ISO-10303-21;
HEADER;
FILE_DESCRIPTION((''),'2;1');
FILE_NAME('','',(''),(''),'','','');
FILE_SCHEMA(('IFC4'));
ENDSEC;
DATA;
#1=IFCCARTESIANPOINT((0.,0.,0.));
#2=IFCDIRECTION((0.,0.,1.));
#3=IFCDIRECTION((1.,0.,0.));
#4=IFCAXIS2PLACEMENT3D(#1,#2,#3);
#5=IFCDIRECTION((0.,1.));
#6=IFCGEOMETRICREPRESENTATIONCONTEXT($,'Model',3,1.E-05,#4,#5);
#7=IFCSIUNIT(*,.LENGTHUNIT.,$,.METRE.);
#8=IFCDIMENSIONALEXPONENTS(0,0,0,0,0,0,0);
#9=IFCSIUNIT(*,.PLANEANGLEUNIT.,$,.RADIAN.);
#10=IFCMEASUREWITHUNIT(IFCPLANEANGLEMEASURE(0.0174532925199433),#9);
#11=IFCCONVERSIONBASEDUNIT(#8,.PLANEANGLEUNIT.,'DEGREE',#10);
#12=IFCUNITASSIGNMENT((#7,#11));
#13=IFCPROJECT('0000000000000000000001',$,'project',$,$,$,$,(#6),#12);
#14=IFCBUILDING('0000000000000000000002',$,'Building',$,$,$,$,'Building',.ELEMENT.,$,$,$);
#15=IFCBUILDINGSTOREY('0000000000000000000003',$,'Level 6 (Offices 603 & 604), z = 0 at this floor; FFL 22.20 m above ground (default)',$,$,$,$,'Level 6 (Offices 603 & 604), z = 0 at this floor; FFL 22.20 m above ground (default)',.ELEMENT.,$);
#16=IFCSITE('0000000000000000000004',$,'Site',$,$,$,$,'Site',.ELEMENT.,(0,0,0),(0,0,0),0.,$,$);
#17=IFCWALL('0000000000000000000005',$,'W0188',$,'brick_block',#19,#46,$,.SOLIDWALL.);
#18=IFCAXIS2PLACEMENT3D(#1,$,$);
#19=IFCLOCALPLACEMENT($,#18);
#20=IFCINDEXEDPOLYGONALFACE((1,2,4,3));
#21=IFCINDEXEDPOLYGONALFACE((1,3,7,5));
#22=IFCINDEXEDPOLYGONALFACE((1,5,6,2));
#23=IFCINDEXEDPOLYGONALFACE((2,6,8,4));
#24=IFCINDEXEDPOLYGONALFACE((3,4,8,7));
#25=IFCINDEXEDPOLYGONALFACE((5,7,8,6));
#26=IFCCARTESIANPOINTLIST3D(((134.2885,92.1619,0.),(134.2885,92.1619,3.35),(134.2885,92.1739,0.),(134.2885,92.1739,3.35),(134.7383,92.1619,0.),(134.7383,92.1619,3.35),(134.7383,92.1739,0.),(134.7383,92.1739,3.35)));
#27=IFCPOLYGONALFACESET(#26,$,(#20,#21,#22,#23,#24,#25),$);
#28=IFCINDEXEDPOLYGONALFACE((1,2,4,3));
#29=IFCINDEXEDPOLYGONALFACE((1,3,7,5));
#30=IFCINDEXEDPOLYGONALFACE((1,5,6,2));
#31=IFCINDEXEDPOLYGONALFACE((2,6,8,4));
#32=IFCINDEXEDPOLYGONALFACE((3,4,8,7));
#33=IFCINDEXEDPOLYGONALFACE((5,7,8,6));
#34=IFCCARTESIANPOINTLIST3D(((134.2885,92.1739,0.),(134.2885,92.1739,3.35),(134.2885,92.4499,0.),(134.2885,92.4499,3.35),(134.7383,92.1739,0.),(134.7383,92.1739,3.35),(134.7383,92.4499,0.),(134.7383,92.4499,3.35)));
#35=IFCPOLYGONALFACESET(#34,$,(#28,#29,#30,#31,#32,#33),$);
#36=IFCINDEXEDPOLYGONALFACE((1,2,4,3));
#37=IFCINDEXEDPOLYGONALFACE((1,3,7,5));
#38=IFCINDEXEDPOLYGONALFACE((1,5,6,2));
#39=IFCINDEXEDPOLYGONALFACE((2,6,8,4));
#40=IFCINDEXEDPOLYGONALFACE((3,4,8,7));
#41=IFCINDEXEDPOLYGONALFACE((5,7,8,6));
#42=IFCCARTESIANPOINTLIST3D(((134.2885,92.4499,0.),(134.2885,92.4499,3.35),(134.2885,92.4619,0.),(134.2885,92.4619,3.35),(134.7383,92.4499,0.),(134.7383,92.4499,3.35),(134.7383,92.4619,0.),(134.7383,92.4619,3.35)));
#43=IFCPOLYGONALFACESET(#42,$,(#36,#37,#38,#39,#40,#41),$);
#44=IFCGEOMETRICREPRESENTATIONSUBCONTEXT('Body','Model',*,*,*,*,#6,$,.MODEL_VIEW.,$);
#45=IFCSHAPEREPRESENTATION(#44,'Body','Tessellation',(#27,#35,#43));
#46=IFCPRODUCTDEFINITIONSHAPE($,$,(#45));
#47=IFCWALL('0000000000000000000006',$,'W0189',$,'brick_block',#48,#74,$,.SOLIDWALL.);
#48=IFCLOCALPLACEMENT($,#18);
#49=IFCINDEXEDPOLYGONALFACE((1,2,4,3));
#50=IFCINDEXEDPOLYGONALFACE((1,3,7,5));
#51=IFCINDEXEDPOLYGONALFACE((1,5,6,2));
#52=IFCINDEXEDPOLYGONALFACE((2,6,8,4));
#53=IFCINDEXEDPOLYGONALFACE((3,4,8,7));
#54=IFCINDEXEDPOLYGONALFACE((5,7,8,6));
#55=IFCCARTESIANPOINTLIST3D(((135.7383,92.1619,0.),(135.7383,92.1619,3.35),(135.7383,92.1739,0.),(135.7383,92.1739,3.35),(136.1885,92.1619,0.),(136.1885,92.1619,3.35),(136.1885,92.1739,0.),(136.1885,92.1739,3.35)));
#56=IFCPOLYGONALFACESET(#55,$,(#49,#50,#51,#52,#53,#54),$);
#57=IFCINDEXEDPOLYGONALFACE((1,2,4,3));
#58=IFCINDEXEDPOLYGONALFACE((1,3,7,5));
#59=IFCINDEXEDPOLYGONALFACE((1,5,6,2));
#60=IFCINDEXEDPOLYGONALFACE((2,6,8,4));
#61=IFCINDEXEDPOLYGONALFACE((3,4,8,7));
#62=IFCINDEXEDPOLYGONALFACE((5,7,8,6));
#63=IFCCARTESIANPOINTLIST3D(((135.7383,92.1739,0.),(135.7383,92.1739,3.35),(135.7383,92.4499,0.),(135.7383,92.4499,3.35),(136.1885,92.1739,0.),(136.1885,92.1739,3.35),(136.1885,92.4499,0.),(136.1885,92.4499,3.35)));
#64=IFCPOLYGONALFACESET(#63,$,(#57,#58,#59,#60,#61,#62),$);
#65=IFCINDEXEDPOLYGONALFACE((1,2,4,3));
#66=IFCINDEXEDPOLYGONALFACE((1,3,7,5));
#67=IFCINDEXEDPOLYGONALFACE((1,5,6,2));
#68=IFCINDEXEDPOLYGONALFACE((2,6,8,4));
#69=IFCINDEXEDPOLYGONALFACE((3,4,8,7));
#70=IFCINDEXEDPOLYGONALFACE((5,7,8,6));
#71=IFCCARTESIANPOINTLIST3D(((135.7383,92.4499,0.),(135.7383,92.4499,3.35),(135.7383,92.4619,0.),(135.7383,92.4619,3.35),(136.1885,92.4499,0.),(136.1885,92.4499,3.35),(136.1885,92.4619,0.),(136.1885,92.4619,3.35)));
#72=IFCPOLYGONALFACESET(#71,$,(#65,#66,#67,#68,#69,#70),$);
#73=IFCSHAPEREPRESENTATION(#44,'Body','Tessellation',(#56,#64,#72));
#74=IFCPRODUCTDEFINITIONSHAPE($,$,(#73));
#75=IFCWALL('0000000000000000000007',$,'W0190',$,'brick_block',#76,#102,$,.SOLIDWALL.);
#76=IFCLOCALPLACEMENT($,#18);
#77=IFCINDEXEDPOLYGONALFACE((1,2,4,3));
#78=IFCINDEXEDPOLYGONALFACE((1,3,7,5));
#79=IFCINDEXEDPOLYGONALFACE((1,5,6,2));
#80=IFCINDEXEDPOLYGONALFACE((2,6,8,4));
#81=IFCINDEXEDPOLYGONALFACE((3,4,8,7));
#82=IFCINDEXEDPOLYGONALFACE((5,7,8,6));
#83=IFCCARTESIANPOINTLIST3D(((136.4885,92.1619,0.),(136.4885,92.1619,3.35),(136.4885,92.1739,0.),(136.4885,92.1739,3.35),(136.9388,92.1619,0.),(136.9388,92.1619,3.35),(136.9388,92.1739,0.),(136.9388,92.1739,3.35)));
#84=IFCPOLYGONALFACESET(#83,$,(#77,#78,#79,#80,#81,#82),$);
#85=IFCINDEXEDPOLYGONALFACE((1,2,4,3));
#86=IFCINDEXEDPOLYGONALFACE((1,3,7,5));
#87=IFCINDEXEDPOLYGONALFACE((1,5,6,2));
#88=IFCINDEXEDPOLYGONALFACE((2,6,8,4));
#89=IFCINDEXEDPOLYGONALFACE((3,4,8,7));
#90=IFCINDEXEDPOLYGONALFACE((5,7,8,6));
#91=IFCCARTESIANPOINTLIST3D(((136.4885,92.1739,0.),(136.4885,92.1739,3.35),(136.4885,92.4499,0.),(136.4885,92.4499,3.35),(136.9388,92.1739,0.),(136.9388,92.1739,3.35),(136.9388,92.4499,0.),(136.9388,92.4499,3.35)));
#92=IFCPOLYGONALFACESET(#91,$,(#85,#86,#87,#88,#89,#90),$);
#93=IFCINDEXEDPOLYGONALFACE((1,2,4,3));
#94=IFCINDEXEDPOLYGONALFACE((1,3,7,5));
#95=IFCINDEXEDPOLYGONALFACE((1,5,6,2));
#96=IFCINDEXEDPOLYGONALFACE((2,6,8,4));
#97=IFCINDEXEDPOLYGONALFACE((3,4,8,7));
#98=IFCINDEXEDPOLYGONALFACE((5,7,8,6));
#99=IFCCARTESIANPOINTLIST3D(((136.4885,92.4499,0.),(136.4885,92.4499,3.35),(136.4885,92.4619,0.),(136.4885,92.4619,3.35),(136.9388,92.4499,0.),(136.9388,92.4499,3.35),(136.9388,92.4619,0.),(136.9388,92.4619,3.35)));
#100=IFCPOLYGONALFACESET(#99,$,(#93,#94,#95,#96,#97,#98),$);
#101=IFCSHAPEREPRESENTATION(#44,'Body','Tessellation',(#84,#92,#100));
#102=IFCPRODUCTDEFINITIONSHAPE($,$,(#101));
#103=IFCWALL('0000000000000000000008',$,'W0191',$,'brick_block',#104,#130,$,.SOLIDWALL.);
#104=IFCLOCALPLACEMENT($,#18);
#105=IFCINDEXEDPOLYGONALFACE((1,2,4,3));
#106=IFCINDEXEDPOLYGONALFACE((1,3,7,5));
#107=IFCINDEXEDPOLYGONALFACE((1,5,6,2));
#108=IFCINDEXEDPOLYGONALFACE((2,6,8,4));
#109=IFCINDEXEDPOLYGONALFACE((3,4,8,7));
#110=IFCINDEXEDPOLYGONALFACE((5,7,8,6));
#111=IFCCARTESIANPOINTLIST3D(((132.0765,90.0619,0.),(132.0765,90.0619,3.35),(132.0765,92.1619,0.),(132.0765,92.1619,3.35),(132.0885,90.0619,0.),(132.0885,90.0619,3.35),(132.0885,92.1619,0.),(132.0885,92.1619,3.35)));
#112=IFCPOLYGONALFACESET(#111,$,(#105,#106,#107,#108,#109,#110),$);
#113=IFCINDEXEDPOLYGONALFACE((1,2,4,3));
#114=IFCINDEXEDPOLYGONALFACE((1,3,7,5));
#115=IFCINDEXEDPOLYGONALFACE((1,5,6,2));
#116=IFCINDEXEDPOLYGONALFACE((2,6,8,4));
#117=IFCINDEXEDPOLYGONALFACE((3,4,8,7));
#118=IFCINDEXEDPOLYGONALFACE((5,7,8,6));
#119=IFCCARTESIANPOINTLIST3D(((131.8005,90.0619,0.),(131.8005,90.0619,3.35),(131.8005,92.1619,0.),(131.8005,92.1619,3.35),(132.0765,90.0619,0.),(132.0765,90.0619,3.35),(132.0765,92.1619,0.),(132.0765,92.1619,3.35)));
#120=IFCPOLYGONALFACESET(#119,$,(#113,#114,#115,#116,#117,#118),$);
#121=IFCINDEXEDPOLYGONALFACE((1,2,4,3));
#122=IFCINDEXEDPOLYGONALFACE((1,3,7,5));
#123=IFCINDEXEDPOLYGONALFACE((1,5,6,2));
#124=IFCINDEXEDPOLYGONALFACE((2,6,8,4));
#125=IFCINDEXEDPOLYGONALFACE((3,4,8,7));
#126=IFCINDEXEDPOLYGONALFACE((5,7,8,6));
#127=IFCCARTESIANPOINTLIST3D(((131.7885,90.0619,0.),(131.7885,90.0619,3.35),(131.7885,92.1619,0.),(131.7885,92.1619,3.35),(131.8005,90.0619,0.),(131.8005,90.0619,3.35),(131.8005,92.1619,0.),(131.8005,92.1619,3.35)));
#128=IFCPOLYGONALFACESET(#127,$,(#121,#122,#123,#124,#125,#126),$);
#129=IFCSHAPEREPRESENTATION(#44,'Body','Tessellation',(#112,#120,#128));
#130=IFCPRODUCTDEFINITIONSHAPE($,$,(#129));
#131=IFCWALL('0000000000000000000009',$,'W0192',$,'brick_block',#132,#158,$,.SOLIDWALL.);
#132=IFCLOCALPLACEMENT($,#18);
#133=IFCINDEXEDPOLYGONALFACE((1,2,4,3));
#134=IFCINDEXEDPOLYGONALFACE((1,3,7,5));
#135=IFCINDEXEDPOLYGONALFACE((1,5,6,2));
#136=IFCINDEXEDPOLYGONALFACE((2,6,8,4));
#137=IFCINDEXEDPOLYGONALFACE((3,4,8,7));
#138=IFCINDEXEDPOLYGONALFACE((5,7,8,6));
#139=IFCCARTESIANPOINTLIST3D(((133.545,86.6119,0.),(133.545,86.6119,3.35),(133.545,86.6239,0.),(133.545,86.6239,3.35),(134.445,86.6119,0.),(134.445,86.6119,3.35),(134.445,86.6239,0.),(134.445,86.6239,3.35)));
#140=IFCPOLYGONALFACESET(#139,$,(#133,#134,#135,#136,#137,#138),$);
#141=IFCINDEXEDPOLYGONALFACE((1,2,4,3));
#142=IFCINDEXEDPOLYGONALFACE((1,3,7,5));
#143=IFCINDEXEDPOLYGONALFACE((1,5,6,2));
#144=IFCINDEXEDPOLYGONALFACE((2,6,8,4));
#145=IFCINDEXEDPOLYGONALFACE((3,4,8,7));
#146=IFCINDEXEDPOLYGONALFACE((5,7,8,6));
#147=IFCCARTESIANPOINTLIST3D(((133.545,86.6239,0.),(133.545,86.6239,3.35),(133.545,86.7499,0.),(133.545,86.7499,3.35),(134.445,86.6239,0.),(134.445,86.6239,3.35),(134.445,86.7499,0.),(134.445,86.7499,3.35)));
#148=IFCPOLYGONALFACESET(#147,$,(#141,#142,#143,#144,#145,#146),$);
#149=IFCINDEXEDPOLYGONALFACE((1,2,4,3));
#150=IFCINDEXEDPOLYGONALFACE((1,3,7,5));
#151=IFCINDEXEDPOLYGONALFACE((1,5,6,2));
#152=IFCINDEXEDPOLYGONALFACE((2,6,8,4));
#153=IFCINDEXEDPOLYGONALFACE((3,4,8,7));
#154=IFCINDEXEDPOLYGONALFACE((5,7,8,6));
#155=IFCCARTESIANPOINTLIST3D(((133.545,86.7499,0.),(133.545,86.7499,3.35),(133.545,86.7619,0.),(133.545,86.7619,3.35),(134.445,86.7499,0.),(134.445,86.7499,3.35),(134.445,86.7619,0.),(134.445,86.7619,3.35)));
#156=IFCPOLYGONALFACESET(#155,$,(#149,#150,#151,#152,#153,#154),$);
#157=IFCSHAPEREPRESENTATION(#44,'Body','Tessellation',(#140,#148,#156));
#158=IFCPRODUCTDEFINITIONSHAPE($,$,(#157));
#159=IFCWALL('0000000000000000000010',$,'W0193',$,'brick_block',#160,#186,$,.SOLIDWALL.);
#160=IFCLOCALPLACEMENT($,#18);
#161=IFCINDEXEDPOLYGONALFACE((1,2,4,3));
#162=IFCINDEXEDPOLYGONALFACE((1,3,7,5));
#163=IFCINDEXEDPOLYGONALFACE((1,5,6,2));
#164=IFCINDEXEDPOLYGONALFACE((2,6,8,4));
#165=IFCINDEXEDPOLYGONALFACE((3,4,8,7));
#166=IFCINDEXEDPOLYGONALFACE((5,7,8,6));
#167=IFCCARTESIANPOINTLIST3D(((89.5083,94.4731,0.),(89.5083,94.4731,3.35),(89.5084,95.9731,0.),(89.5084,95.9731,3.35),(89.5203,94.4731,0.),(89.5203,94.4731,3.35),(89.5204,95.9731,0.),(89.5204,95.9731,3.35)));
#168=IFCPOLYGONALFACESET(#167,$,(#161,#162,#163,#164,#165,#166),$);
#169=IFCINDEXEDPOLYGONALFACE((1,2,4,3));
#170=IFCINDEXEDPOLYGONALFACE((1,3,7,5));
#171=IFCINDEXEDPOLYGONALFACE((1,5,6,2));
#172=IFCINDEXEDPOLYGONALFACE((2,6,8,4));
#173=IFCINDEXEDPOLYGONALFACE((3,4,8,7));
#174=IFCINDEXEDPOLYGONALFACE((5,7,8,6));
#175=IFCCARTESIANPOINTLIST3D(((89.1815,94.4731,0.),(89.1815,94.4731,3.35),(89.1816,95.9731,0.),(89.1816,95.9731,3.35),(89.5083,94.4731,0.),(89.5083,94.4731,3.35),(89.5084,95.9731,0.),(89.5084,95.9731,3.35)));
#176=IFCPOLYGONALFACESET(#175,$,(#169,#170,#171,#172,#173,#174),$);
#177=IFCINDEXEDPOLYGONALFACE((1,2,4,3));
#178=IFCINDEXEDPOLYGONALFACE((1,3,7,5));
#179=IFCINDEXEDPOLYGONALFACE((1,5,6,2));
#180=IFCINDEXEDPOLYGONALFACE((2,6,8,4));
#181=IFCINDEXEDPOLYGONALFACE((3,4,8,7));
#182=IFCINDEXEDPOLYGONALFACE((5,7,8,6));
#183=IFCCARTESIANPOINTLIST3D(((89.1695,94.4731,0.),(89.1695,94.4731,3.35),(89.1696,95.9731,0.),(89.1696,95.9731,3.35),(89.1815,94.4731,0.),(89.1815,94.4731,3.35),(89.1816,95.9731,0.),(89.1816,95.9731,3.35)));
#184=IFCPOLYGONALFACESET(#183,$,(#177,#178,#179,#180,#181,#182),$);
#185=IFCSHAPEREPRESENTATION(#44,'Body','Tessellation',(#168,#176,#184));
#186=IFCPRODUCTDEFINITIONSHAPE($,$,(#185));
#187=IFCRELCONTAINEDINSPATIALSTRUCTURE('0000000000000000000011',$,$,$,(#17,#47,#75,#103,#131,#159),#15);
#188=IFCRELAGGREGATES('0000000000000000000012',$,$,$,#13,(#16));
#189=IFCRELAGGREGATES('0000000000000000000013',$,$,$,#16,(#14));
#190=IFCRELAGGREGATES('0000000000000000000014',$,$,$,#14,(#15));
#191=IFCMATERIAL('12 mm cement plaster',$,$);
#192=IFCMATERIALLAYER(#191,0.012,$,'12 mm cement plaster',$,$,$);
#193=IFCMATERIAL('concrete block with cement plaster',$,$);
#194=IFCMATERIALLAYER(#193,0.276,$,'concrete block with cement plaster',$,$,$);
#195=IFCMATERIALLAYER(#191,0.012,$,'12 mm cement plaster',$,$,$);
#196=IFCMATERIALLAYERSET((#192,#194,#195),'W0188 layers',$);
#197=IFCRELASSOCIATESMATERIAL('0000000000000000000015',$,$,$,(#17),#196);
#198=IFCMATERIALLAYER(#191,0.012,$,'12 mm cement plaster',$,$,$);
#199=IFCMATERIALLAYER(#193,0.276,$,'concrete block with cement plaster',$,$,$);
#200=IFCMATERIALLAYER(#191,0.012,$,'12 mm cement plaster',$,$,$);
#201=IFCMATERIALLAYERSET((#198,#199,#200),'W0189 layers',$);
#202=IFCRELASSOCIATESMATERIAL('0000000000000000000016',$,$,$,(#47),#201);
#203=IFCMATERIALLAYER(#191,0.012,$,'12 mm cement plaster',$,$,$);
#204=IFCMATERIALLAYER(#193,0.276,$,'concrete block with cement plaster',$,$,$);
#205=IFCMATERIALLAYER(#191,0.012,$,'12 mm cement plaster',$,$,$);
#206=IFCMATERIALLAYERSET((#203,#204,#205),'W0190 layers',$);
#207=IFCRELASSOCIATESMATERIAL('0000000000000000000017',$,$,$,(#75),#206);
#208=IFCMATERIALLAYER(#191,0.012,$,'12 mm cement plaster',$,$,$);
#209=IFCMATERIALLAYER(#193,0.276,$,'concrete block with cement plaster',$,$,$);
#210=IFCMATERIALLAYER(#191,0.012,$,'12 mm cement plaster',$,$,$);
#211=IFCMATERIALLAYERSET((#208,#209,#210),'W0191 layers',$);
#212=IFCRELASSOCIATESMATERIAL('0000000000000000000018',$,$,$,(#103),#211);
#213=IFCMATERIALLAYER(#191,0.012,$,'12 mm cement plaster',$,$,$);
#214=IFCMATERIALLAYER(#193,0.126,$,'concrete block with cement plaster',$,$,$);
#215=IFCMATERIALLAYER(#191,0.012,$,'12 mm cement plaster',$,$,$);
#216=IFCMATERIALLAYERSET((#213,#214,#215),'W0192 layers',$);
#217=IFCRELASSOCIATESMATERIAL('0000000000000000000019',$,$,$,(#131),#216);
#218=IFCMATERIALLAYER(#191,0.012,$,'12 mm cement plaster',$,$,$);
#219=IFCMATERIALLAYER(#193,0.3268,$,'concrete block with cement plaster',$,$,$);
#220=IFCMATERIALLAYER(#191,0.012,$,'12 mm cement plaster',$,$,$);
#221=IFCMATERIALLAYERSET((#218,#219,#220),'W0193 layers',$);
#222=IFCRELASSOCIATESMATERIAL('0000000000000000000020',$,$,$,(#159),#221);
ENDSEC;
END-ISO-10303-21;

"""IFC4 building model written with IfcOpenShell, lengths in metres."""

from ifc_helpers import new_model, entity, si_unit, converted_unit, direction, frame, frame_2d, origin_with_axes, origin_2d_with_axis, place, context, subcontext, project, spatial, rectangle, extrude, material, layer, layer_set, layer_usage, element, save


model = new_model("IFC4")

# Units and contexts
model_context = context("Model", 3, precision=1e-05, world=origin_with_axes(), true_north=direction((0.0, 1.0)))
body_context = subcontext(model_context, "Body", "Model", "MODEL_VIEW")
ifc_project = project(units=[si_unit("LENGTHUNIT", "METRE"), converted_unit("PLANEANGLEUNIT", "DEGREE", entity("IfcPlaneAngleMeasure", 0.0174532925199433), si_unit("PLANEANGLEUNIT", "RADIAN"), dimensions=[0, 0, 0, 0, 0, 0, 0])], contexts=[model_context])

# Site, building, storey
site = spatial("IfcSite", under=ifc_project, Name="Site", LongName="Site", CompositionType="ELEMENT", RefLatitude=(0, 0, 0), RefLongitude=(0, 0, 0), RefElevation=0.0)
building = spatial("IfcBuilding", under=site, Name="Building", LongName="Building", CompositionType="ELEMENT")
storey = spatial("IfcBuildingStorey", under=building, Name="Level 6 (Offices 603 & 604), z = 0 at this floor; FFL 22.20 m above ground (default)", LongName="Level 6 (Offices 603 & 604), z = 0 at this floor; FFL 22.20 m above ground (default)", CompositionType="ELEMENT")

# Shared definitions
placement = place(None, origin_with_axes())

# Walls
ifc_material_1 = material(Name="12 mm cement plaster")
ifc_material_2 = material(Name="concrete block with cement plaster")
ifc_layer_1 = layer(ifc_material_1, 0.012, Name="12 mm cement plaster")
ifc_layer_2 = layer(ifc_material_2, 0.276, Name="concrete block with cement plaster")
ifc_layer_3 = layer(ifc_material_1, 0.012, Name="12 mm cement plaster")
ifc_layer_set_1 = layer_set([ifc_layer_1, ifc_layer_2, ifc_layer_3], Name="W0188 layers")
ifc_layer_usage_1 = layer_usage(ifc_layer_set_1, "AXIS2", "POSITIVE", -0.15)
element("IfcWall", 1, at=placement, inside=storey, material=ifc_layer_usage_1, Name="W0188", ObjectType="brick_block", PredefinedType="SOLIDWALL", context=body_context, shape_type="SweptSolid", body=[
    extrude(rectangle(XDim=0.4498, YDim=0.012, at=origin_2d_with_axis()), frame((134.5134, 92.1679, 0.0), z_axis=(0.0, 0.0, 1.0), x_axis=(1.0, 0.0, 0.0)), (0.0, 0.0, 1.0), 3.35),
    extrude(rectangle(XDim=0.4498, YDim=0.276, at=frame_2d((0.0, 0.144), x_axis=(1.0, 0.0))), frame((134.5134, 92.1679, 0.0), z_axis=(0.0, 0.0, 1.0), x_axis=(1.0, 0.0, 0.0)), (0.0, 0.0, 1.0), 3.35),
    extrude(rectangle(XDim=0.4498, YDim=0.012, at=frame_2d((0.0, 0.288), x_axis=(1.0, 0.0))), frame((134.5134, 92.1679, 0.0), z_axis=(0.0, 0.0, 1.0), x_axis=(1.0, 0.0, 0.0)), (0.0, 0.0, 1.0), 3.35),
])
ifc_layer_4 = layer(ifc_material_1, 0.012, Name="12 mm cement plaster")
ifc_layer_5 = layer(ifc_material_2, 0.276, Name="concrete block with cement plaster")
ifc_layer_6 = layer(ifc_material_1, 0.012, Name="12 mm cement plaster")
ifc_layer_set_2 = layer_set([ifc_layer_4, ifc_layer_5, ifc_layer_6], Name="W0189 layers")
ifc_layer_usage_2 = layer_usage(ifc_layer_set_2, "AXIS2", "POSITIVE", -0.15)
element("IfcWall", 2, at=placement, inside=storey, material=ifc_layer_usage_2, Name="W0189", ObjectType="brick_block", PredefinedType="SOLIDWALL", context=body_context, shape_type="SweptSolid", body=[
    extrude(rectangle(XDim=0.4502, YDim=0.012, at=origin_2d_with_axis()), frame((135.9634, 92.1679, 0.0), z_axis=(0.0, 0.0, 1.0), x_axis=(1.0, 0.0, 0.0)), (0.0, 0.0, 1.0), 3.35),
    extrude(rectangle(XDim=0.4502, YDim=0.276, at=frame_2d((0.0, 0.144), x_axis=(1.0, 0.0))), frame((135.9634, 92.1679, 0.0), z_axis=(0.0, 0.0, 1.0), x_axis=(1.0, 0.0, 0.0)), (0.0, 0.0, 1.0), 3.35),
    extrude(rectangle(XDim=0.4502, YDim=0.012, at=frame_2d((0.0, 0.288), x_axis=(1.0, 0.0))), frame((135.9634, 92.1679, 0.0), z_axis=(0.0, 0.0, 1.0), x_axis=(1.0, 0.0, 0.0)), (0.0, 0.0, 1.0), 3.35),
])
ifc_layer_7 = layer(ifc_material_1, 0.012, Name="12 mm cement plaster")
ifc_layer_8 = layer(ifc_material_2, 0.276, Name="concrete block with cement plaster")
ifc_layer_9 = layer(ifc_material_1, 0.012, Name="12 mm cement plaster")
ifc_layer_set_3 = layer_set([ifc_layer_7, ifc_layer_8, ifc_layer_9], Name="W0190 layers")
ifc_layer_usage_3 = layer_usage(ifc_layer_set_3, "AXIS2", "POSITIVE", -0.15)
element("IfcWall", 3, at=placement, inside=storey, material=ifc_layer_usage_3, Name="W0190", ObjectType="brick_block", PredefinedType="SOLIDWALL", context=body_context, shape_type="SweptSolid", body=[
    extrude(rectangle(XDim=0.4503, YDim=0.012, at=origin_2d_with_axis()), frame((136.7137, 92.1679, 0.0), z_axis=(0.0, 0.0, 1.0), x_axis=(1.0, 0.0, 0.0)), (0.0, 0.0, 1.0), 3.35),
    extrude(rectangle(XDim=0.4503, YDim=0.276, at=frame_2d((0.0, 0.144), x_axis=(1.0, 0.0))), frame((136.7137, 92.1679, 0.0), z_axis=(0.0, 0.0, 1.0), x_axis=(1.0, 0.0, 0.0)), (0.0, 0.0, 1.0), 3.35),
    extrude(rectangle(XDim=0.4503, YDim=0.012, at=frame_2d((0.0, 0.288), x_axis=(1.0, 0.0))), frame((136.7137, 92.1679, 0.0), z_axis=(0.0, 0.0, 1.0), x_axis=(1.0, 0.0, 0.0)), (0.0, 0.0, 1.0), 3.35),
])
ifc_layer_10 = layer(ifc_material_1, 0.012, Name="12 mm cement plaster")
ifc_layer_11 = layer(ifc_material_2, 0.276, Name="concrete block with cement plaster")
ifc_layer_12 = layer(ifc_material_1, 0.012, Name="12 mm cement plaster")
ifc_layer_set_4 = layer_set([ifc_layer_10, ifc_layer_11, ifc_layer_12], Name="W0191 layers")
ifc_layer_usage_4 = layer_usage(ifc_layer_set_4, "AXIS2", "POSITIVE", -0.15)
element("IfcWall", 4, at=placement, inside=storey, material=ifc_layer_usage_4, Name="W0191", ObjectType="brick_block", PredefinedType="SOLIDWALL", context=body_context, shape_type="SweptSolid", body=[
    extrude(rectangle(XDim=2.1, YDim=0.012, at=frame_2d((0.0, 0.0), x_axis=(0.0, 1.0))), frame((132.0825, 91.1119, 0.0), z_axis=(0.0, 0.0, 1.0), x_axis=(1.0, 0.0, 0.0)), (0.0, 0.0, 1.0), 3.35),
    extrude(rectangle(XDim=2.1, YDim=0.276, at=frame_2d((-0.144, 0.0), x_axis=(0.0, 1.0))), frame((132.0825, 91.1119, 0.0), z_axis=(0.0, 0.0, 1.0), x_axis=(1.0, 0.0, 0.0)), (0.0, 0.0, 1.0), 3.35),
    extrude(rectangle(XDim=2.1, YDim=0.012, at=frame_2d((-0.288, 0.0), x_axis=(0.0, 1.0))), frame((132.0825, 91.1119, 0.0), z_axis=(0.0, 0.0, 1.0), x_axis=(1.0, 0.0, 0.0)), (0.0, 0.0, 1.0), 3.35),
])
ifc_layer_13 = layer(ifc_material_1, 0.012, Name="12 mm cement plaster")
ifc_layer_14 = layer(ifc_material_2, 0.126, Name="concrete block with cement plaster")
ifc_layer_15 = layer(ifc_material_1, 0.012, Name="12 mm cement plaster")
ifc_layer_set_5 = layer_set([ifc_layer_13, ifc_layer_14, ifc_layer_15], Name="W0192 layers")
ifc_layer_usage_5 = layer_usage(ifc_layer_set_5, "AXIS2", "POSITIVE", -0.075)
element("IfcWall", 5, at=placement, inside=storey, material=ifc_layer_usage_5, Name="W0192", ObjectType="brick_block", PredefinedType="SOLIDWALL", context=body_context, shape_type="SweptSolid", body=[
    extrude(rectangle(XDim=0.9, YDim=0.012, at=frame_2d((0.0, 0.0), x_axis=(1.0, 0.0))), frame((133.995, 86.6179, 0.0), z_axis=(0.0, 0.0, 1.0), x_axis=(1.0, 0.0, 0.0)), (0.0, 0.0, 1.0), 3.35),
    extrude(rectangle(XDim=0.9, YDim=0.126, at=frame_2d((0.0, 0.069), x_axis=(1.0, 0.0))), frame((133.995, 86.6179, 0.0), z_axis=(0.0, 0.0, 1.0), x_axis=(1.0, 0.0, 0.0)), (0.0, 0.0, 1.0), 3.35),
    extrude(rectangle(XDim=0.9, YDim=0.012, at=frame_2d((0.0, 0.138), x_axis=(1.0, 0.0))), frame((133.995, 86.6179, 0.0), z_axis=(0.0, 0.0, 1.0), x_axis=(1.0, 0.0, 0.0)), (0.0, 0.0, 1.0), 3.35),
])
ifc_layer_16 = layer(ifc_material_1, 0.012, Name="12 mm cement plaster")
ifc_layer_17 = layer(ifc_material_2, 0.3268, Name="concrete block with cement plaster")
ifc_layer_18 = layer(ifc_material_1, 0.012, Name="12 mm cement plaster")
ifc_layer_set_6 = layer_set([ifc_layer_16, ifc_layer_17, ifc_layer_18], Name="W0193 layers")
ifc_layer_usage_6 = layer_usage(ifc_layer_set_6, "AXIS2", "POSITIVE", -0.1754)
element("IfcWall", 6, at=placement, inside=storey, material=ifc_layer_usage_6, Name="W0193", ObjectType="brick_block", PredefinedType="SOLIDWALL", context=body_context, shape_type="SweptSolid", body=[
    extrude(rectangle(XDim=1.5, YDim=0.012, at=frame_2d((0.0, 0.0), x_axis=(0.000067, 1.0))), frame((89.5143, 95.2231, 0.0), z_axis=(0.0, 0.0, 1.0), x_axis=(1.0, 0.0, 0.0)), (0.0, 0.0, 1.0), 3.35),
    extrude(rectangle(XDim=1.5, YDim=0.3268, at=frame_2d((-0.1694, 0.0), x_axis=(0.000067, 1.0))), frame((89.5143, 95.2231, 0.0), z_axis=(0.0, 0.0, 1.0), x_axis=(1.0, 0.0, 0.0)), (0.0, 0.0, 1.0), 3.35),
    extrude(rectangle(XDim=1.5, YDim=0.012, at=frame_2d((-0.3388, 0.0), x_axis=(0.000067, 1.0))), frame((89.5143, 95.2231, 0.0), z_axis=(0.0, 0.0, 1.0), x_axis=(1.0, 0.0, 0.0)), (0.0, 0.0, 1.0), 3.35),
])

save(model, "model.ifc")
